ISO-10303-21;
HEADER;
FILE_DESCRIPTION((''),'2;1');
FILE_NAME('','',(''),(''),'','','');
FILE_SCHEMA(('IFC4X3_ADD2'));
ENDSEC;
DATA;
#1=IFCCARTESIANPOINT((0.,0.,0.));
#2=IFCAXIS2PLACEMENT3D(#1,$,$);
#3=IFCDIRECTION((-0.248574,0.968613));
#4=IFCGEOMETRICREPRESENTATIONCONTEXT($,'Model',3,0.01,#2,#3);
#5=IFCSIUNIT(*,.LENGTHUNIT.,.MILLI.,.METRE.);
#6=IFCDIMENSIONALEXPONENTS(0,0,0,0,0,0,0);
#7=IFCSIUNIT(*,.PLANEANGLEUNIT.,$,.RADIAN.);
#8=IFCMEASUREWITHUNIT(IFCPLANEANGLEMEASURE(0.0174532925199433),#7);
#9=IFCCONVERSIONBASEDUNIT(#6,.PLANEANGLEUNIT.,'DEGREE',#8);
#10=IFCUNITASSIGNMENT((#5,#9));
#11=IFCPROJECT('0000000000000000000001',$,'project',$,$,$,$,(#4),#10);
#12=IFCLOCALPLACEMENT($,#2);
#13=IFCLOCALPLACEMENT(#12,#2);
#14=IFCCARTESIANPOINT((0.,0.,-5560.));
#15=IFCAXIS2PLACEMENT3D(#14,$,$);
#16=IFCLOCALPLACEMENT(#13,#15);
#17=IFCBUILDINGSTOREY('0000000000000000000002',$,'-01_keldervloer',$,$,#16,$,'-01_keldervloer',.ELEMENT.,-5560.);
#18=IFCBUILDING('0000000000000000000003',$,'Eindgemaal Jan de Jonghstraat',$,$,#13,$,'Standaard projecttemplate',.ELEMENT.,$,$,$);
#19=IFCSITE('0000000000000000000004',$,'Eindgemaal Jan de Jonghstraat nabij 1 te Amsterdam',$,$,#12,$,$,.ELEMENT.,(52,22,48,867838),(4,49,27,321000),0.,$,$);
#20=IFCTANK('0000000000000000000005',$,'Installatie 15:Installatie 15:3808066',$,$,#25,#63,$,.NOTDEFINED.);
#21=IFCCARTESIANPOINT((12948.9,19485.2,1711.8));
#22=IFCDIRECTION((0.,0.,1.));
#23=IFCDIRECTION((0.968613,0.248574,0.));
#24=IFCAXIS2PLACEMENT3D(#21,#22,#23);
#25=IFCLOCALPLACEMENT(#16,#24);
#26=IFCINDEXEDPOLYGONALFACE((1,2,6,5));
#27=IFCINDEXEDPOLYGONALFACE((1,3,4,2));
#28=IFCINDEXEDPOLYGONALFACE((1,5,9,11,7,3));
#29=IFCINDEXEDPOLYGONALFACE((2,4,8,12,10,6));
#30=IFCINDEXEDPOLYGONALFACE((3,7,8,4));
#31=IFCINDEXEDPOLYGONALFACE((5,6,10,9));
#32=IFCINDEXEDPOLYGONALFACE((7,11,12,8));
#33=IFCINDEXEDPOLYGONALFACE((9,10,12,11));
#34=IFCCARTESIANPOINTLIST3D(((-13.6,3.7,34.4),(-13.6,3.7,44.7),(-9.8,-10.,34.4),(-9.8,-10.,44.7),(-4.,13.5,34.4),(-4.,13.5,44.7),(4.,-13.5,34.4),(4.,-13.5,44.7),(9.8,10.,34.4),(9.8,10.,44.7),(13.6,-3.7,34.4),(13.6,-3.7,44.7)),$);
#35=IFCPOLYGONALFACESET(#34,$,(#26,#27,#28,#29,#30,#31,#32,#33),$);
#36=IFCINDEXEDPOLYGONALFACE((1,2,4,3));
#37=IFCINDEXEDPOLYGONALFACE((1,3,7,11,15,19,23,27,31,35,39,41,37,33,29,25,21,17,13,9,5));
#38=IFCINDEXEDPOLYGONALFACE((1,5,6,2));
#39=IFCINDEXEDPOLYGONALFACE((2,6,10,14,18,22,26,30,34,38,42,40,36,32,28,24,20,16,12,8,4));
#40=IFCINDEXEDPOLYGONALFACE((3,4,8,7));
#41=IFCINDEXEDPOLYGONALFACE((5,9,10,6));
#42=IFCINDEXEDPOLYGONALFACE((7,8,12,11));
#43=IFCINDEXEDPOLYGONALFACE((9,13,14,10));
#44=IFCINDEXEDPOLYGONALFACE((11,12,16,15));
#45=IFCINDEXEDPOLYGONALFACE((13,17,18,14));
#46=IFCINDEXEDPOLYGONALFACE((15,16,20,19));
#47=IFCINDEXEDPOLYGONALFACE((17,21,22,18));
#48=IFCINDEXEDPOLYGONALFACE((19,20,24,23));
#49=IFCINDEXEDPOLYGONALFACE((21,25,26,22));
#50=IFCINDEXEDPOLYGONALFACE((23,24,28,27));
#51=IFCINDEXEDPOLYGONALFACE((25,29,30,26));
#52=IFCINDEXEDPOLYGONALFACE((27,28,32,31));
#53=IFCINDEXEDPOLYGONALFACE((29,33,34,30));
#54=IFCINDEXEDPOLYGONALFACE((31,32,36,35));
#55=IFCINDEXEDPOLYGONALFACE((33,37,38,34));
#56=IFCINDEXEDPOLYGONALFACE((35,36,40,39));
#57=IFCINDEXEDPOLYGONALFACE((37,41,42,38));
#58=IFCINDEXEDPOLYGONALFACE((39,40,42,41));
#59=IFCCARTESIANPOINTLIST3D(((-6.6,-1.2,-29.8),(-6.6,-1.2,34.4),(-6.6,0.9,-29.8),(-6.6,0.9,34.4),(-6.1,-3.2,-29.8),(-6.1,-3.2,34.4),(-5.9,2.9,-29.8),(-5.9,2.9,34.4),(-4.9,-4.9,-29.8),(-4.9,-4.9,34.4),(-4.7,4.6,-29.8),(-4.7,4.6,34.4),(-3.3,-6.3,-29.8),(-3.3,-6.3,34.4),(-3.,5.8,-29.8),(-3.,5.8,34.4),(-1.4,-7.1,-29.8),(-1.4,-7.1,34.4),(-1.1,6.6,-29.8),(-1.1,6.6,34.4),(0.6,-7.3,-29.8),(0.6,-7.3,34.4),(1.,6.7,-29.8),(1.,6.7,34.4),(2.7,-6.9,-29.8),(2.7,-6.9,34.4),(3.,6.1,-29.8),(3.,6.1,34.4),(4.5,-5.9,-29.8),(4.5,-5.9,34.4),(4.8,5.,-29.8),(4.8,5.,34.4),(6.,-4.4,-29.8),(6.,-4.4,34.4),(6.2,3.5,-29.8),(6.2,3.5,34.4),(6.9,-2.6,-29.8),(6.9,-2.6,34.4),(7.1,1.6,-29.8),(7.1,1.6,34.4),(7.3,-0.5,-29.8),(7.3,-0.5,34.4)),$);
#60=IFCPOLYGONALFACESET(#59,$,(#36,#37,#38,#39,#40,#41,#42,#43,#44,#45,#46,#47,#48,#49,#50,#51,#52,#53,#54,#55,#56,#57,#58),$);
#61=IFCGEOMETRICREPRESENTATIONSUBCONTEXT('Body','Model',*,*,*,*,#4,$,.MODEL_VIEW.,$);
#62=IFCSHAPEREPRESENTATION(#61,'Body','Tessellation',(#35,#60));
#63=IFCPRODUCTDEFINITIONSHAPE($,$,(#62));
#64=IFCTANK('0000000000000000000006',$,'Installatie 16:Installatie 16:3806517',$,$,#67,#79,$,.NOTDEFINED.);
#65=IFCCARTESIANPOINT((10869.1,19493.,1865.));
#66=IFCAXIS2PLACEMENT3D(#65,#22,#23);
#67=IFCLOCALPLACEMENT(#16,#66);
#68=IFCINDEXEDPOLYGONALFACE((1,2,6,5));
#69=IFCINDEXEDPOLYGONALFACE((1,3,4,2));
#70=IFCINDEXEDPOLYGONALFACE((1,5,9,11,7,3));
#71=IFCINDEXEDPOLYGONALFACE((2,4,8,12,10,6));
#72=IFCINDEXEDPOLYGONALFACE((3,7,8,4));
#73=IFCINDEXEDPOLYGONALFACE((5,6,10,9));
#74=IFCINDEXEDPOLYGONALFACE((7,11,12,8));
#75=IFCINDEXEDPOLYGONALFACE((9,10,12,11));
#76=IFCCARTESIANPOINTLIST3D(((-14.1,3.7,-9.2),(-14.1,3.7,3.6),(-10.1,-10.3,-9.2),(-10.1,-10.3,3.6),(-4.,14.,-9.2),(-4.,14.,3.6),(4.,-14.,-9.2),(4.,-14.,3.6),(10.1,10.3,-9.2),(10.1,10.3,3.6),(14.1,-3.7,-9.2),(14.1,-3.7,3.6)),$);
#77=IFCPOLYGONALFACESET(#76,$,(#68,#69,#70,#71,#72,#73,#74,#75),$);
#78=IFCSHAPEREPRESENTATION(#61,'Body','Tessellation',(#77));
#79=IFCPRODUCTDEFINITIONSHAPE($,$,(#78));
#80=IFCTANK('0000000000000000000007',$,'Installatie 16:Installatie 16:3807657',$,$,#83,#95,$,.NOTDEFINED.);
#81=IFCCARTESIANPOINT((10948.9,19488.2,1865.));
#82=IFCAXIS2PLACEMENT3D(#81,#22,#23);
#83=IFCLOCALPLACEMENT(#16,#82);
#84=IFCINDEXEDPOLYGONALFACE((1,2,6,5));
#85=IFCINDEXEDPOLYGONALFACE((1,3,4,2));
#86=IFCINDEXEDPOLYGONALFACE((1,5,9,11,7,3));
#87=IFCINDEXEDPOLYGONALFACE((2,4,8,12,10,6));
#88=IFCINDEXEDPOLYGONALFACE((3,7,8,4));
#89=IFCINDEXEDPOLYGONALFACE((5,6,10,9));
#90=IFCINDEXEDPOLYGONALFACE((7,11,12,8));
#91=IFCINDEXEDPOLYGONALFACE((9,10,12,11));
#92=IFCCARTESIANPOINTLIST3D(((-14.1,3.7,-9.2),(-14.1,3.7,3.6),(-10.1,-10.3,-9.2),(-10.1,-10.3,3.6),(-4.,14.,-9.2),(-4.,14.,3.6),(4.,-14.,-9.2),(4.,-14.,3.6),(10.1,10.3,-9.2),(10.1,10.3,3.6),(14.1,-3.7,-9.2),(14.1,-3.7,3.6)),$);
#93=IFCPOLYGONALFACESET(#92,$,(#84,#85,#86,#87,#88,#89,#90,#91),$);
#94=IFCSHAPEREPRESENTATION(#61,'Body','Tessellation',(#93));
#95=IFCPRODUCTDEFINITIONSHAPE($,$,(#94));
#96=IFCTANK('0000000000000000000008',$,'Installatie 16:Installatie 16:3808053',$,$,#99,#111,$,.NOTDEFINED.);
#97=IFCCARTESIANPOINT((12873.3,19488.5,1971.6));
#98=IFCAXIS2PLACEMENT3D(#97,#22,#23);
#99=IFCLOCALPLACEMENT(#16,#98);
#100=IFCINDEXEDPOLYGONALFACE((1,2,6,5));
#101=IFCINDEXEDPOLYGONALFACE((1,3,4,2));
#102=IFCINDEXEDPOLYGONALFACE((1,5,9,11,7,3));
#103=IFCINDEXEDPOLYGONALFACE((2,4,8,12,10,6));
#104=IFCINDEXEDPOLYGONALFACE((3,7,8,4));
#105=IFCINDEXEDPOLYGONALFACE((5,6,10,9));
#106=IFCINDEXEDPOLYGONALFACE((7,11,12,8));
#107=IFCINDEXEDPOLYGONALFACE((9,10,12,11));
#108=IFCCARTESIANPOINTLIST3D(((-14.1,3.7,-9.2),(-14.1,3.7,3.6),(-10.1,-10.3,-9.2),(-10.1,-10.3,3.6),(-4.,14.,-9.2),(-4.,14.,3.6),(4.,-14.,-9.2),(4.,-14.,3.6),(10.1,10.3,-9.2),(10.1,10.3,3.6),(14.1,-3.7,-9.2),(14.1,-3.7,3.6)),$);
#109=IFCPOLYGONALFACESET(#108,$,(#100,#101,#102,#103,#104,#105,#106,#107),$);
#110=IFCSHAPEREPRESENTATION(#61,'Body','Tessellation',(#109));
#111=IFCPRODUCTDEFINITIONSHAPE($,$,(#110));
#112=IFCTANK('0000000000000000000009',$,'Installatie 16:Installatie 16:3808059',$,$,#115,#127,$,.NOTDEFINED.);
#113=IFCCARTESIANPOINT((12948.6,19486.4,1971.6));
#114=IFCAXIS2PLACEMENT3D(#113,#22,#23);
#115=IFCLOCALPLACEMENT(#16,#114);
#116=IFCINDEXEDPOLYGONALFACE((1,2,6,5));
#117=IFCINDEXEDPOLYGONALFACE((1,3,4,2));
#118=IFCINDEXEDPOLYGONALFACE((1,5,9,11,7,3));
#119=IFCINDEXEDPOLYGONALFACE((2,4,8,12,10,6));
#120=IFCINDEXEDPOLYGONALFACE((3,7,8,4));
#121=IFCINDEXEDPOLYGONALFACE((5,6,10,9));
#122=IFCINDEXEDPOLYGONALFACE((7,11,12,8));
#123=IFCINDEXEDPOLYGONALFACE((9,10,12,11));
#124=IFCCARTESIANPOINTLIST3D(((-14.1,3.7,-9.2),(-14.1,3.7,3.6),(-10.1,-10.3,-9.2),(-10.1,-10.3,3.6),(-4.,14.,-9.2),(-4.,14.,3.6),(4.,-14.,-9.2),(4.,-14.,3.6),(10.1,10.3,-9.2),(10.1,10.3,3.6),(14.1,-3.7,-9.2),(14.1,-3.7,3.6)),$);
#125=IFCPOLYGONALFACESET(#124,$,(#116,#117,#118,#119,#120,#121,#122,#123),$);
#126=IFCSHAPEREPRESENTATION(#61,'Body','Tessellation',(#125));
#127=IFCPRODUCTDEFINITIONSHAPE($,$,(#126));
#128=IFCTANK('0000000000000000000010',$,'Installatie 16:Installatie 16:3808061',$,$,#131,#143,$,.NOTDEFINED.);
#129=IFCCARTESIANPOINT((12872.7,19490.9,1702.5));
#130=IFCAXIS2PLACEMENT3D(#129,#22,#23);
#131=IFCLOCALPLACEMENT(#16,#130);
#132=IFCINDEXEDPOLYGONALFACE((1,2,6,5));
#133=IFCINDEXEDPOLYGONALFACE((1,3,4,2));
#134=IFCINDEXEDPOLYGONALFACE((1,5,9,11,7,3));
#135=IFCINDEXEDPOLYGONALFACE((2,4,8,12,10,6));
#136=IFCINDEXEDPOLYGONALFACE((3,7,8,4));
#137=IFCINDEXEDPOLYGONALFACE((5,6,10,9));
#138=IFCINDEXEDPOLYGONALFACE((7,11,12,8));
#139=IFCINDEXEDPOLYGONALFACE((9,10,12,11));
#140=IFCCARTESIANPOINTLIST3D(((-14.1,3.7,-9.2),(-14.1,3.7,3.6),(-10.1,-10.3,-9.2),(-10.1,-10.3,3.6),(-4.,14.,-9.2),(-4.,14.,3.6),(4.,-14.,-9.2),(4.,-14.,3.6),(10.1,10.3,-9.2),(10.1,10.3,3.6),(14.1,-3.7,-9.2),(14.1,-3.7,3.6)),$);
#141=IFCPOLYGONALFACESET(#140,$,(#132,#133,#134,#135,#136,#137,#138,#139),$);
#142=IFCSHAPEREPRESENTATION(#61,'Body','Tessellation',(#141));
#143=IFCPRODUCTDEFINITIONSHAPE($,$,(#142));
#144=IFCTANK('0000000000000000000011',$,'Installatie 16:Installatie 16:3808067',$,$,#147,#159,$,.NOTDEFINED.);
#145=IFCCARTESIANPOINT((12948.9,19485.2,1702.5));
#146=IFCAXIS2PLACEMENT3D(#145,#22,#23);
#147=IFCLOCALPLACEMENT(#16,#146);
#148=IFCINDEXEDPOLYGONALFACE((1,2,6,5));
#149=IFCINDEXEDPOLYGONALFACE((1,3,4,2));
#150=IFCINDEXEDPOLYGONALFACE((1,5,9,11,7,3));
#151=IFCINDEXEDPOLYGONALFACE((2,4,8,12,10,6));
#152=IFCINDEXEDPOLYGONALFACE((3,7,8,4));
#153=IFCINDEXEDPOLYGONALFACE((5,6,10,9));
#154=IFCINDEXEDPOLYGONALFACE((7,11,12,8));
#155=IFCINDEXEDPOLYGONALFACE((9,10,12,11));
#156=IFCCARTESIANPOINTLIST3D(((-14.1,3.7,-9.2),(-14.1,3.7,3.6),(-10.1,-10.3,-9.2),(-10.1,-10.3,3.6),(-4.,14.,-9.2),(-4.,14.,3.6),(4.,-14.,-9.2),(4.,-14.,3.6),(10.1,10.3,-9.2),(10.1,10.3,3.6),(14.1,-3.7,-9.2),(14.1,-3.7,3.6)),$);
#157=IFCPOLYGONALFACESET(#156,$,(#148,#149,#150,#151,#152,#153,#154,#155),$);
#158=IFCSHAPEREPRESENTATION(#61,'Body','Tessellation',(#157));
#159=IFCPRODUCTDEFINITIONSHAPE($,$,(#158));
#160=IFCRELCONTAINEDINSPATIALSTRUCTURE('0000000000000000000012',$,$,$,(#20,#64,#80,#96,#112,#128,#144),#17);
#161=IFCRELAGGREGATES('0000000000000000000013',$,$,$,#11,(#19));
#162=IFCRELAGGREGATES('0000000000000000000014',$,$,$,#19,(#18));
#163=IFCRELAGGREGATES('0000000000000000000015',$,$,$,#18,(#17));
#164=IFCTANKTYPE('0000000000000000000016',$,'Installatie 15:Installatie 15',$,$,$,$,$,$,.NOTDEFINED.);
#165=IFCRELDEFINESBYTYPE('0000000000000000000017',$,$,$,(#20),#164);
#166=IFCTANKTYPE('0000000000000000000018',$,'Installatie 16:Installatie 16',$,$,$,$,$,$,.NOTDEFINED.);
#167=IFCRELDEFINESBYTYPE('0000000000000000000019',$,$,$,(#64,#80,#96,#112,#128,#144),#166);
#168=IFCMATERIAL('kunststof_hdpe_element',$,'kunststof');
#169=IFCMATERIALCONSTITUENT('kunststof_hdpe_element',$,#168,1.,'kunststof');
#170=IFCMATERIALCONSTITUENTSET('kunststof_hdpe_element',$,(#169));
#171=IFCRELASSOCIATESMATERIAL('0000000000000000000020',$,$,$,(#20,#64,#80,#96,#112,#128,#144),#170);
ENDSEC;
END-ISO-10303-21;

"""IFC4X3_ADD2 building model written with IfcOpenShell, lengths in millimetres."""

from ifc_helpers import new_model, entity, si_unit, converted_unit, direction, frame, frame_2d, origin, place, context, subcontext, project, spatial, polyline, circle, outline, extrude, source, transform, mapped, material, constituent, constituent_set, type_object, type_shapes, element, save


model = new_model("IFC4X3_ADD2")

# Units and contexts
model_context = context("Model", 3, precision=0.01, world=origin(), true_north=direction((-0.248574, 0.968613)))
body_context = subcontext(model_context, "Body", "Model", "MODEL_VIEW")
ifc_project = project(units=[si_unit("LENGTHUNIT", "METRE", prefix="MILLI"), converted_unit("PLANEANGLEUNIT", "DEGREE", entity("IfcPlaneAngleMeasure", 0.0174532925199433), si_unit("PLANEANGLEUNIT", "RADIAN"), dimensions=[0, 0, 0, 0, 0, 0, 0])], contexts=[model_context])

# Site, building, storey
site_placement = place(None, origin())
site = spatial("IfcSite", under=ifc_project, at=site_placement, Name="Eindgemaal Jan de Jonghstraat nabij 1 te Amsterdam", CompositionType="ELEMENT", RefLatitude=(52, 22, 48, 867838), RefLongitude=(4, 49, 27, 321000), RefElevation=0.0)
building_placement = place(site_placement, origin())
building = spatial("IfcBuilding", under=site, at=building_placement, Name="Eindgemaal Jan de Jonghstraat", LongName="Standaard projecttemplate", CompositionType="ELEMENT")
storey_placement = place(building_placement, frame((0.0, 0.0, -5560.0)))
storey = spatial("IfcBuildingStorey", under=building, at=storey_placement, Name="-01_keldervloer", LongName="-01_keldervloer", CompositionType="ELEMENT", Elevation=-5560.0)

# Tanks
ifc_material_1 = material(Name="kunststof_hdpe_element", Category="kunststof")
ifc_constituent_1 = constituent(ifc_material_1, Name="kunststof_hdpe_element", Category="kunststof", fraction=1.0)
ifc_constituent_set_1 = constituent_set(constituents=[ifc_constituent_1], Name="kunststof_hdpe_element")
tank_type_1 = type_object("IfcTankType", Name="Installatie 15:Installatie 15", PredefinedType="NOTDEFINED")
shared_shape_1 = source(origin(), body_context, "Body", "SweptSolid", [
    extrude(outline(polyline([(-7.0, -12.1), (7.3, -12.1), (14.1, -0.2), (7.0, 12.1), (-7.3, 12.1), (-14.1, 0.2), (-7.0, -12.1)])), frame((0.0, 0.0, 34.4), z_axis=(0.0, 0.0, 1.0), x_axis=(-0.968613, 0.248574, 0.0)), (0.0, 0.0, 1.0), 10.3),
    extrude(circle(Radius=7.0, at=frame_2d((0.0, 0.0), x_axis=(1.0, 0.0))), frame((0.3, -0.3, -29.8), z_axis=(0.0, 0.0, 1.0), x_axis=(-0.248574, -0.968613, 0.0)), (0.0, 0.0, 1.0), 64.2),
])
type_shapes(tank_type_1, [shared_shape_1])
for number, where, z_axis, x_axis, name in (
    (1, (12948.9, 19485.2, 1711.8), (0.0, 0.0, 1.0), (0.968613, 0.248574, 0.0), "Installatie 15:Installatie 15:3808066"),
):
    element("IfcTank", number, at=place(storey_placement, frame(where, z_axis=z_axis, x_axis=x_axis)), inside=storey, type_object=tank_type_1, material=ifc_constituent_set_1, Name=name, PredefinedType="NOTDEFINED", context=body_context, shape_type="MappedRepresentation", body=[
        mapped(shared_shape_1, transform((0.0, 0.0, 0.0), scale=1.0)),
    ])
tank_type_2 = type_object("IfcTankType", Name="Installatie 16:Installatie 16", PredefinedType="NOTDEFINED")
shared_shape_2 = source(origin(), body_context, "Body", "SweptSolid", [
    extrude(outline(polyline([(-7.2, -12.5), (7.4, -12.5), (14.6, -0.1), (7.2, 12.5), (-7.4, 12.5), (-14.6, 0.1), (-7.2, -12.5)])), frame((0.0, 0.0, -9.2), z_axis=(0.0, 0.0, 1.0), x_axis=(-0.968613, 0.248574, 0.0)), (0.0, 0.0, 1.0), 12.8),
])
type_shapes(tank_type_2, [shared_shape_2])
for number, where, z_axis, x_axis, name in (
    (2, (10869.1, 19493.0, 1865.0), (0.0, 0.0, 1.0), (0.968613, 0.248574, 0.0), "Installatie 16:Installatie 16:3806517"),
    (3, (10948.9, 19488.2, 1865.0), (0.0, 0.0, 1.0), (0.968613, 0.248574, 0.0), "Installatie 16:Installatie 16:3807657"),
    (4, (12873.3, 19488.5, 1971.6), (0.0, 0.0, 1.0), (0.968613, 0.248574, 0.0), "Installatie 16:Installatie 16:3808053"),
    (5, (12948.6, 19486.4, 1971.6), (0.0, 0.0, 1.0), (0.968613, 0.248574, 0.0), "Installatie 16:Installatie 16:3808059"),
    (6, (12872.7, 19490.9, 1702.5), (0.0, 0.0, 1.0), (0.968613, 0.248574, 0.0), "Installatie 16:Installatie 16:3808061"),
    (7, (12948.9, 19485.2, 1702.5), (0.0, 0.0, 1.0), (0.968613, 0.248574, 0.0), "Installatie 16:Installatie 16:3808067"),
):
    element("IfcTank", number, at=place(storey_placement, frame(where, z_axis=z_axis, x_axis=x_axis)), inside=storey, type_object=tank_type_2, material=ifc_constituent_set_1, Name=name, PredefinedType="NOTDEFINED", context=body_context, shape_type="MappedRepresentation", body=[
        mapped(shared_shape_2, transform((0.0, 0.0, 0.0), scale=1.0)),
    ])

save(model, "model.ifc")
